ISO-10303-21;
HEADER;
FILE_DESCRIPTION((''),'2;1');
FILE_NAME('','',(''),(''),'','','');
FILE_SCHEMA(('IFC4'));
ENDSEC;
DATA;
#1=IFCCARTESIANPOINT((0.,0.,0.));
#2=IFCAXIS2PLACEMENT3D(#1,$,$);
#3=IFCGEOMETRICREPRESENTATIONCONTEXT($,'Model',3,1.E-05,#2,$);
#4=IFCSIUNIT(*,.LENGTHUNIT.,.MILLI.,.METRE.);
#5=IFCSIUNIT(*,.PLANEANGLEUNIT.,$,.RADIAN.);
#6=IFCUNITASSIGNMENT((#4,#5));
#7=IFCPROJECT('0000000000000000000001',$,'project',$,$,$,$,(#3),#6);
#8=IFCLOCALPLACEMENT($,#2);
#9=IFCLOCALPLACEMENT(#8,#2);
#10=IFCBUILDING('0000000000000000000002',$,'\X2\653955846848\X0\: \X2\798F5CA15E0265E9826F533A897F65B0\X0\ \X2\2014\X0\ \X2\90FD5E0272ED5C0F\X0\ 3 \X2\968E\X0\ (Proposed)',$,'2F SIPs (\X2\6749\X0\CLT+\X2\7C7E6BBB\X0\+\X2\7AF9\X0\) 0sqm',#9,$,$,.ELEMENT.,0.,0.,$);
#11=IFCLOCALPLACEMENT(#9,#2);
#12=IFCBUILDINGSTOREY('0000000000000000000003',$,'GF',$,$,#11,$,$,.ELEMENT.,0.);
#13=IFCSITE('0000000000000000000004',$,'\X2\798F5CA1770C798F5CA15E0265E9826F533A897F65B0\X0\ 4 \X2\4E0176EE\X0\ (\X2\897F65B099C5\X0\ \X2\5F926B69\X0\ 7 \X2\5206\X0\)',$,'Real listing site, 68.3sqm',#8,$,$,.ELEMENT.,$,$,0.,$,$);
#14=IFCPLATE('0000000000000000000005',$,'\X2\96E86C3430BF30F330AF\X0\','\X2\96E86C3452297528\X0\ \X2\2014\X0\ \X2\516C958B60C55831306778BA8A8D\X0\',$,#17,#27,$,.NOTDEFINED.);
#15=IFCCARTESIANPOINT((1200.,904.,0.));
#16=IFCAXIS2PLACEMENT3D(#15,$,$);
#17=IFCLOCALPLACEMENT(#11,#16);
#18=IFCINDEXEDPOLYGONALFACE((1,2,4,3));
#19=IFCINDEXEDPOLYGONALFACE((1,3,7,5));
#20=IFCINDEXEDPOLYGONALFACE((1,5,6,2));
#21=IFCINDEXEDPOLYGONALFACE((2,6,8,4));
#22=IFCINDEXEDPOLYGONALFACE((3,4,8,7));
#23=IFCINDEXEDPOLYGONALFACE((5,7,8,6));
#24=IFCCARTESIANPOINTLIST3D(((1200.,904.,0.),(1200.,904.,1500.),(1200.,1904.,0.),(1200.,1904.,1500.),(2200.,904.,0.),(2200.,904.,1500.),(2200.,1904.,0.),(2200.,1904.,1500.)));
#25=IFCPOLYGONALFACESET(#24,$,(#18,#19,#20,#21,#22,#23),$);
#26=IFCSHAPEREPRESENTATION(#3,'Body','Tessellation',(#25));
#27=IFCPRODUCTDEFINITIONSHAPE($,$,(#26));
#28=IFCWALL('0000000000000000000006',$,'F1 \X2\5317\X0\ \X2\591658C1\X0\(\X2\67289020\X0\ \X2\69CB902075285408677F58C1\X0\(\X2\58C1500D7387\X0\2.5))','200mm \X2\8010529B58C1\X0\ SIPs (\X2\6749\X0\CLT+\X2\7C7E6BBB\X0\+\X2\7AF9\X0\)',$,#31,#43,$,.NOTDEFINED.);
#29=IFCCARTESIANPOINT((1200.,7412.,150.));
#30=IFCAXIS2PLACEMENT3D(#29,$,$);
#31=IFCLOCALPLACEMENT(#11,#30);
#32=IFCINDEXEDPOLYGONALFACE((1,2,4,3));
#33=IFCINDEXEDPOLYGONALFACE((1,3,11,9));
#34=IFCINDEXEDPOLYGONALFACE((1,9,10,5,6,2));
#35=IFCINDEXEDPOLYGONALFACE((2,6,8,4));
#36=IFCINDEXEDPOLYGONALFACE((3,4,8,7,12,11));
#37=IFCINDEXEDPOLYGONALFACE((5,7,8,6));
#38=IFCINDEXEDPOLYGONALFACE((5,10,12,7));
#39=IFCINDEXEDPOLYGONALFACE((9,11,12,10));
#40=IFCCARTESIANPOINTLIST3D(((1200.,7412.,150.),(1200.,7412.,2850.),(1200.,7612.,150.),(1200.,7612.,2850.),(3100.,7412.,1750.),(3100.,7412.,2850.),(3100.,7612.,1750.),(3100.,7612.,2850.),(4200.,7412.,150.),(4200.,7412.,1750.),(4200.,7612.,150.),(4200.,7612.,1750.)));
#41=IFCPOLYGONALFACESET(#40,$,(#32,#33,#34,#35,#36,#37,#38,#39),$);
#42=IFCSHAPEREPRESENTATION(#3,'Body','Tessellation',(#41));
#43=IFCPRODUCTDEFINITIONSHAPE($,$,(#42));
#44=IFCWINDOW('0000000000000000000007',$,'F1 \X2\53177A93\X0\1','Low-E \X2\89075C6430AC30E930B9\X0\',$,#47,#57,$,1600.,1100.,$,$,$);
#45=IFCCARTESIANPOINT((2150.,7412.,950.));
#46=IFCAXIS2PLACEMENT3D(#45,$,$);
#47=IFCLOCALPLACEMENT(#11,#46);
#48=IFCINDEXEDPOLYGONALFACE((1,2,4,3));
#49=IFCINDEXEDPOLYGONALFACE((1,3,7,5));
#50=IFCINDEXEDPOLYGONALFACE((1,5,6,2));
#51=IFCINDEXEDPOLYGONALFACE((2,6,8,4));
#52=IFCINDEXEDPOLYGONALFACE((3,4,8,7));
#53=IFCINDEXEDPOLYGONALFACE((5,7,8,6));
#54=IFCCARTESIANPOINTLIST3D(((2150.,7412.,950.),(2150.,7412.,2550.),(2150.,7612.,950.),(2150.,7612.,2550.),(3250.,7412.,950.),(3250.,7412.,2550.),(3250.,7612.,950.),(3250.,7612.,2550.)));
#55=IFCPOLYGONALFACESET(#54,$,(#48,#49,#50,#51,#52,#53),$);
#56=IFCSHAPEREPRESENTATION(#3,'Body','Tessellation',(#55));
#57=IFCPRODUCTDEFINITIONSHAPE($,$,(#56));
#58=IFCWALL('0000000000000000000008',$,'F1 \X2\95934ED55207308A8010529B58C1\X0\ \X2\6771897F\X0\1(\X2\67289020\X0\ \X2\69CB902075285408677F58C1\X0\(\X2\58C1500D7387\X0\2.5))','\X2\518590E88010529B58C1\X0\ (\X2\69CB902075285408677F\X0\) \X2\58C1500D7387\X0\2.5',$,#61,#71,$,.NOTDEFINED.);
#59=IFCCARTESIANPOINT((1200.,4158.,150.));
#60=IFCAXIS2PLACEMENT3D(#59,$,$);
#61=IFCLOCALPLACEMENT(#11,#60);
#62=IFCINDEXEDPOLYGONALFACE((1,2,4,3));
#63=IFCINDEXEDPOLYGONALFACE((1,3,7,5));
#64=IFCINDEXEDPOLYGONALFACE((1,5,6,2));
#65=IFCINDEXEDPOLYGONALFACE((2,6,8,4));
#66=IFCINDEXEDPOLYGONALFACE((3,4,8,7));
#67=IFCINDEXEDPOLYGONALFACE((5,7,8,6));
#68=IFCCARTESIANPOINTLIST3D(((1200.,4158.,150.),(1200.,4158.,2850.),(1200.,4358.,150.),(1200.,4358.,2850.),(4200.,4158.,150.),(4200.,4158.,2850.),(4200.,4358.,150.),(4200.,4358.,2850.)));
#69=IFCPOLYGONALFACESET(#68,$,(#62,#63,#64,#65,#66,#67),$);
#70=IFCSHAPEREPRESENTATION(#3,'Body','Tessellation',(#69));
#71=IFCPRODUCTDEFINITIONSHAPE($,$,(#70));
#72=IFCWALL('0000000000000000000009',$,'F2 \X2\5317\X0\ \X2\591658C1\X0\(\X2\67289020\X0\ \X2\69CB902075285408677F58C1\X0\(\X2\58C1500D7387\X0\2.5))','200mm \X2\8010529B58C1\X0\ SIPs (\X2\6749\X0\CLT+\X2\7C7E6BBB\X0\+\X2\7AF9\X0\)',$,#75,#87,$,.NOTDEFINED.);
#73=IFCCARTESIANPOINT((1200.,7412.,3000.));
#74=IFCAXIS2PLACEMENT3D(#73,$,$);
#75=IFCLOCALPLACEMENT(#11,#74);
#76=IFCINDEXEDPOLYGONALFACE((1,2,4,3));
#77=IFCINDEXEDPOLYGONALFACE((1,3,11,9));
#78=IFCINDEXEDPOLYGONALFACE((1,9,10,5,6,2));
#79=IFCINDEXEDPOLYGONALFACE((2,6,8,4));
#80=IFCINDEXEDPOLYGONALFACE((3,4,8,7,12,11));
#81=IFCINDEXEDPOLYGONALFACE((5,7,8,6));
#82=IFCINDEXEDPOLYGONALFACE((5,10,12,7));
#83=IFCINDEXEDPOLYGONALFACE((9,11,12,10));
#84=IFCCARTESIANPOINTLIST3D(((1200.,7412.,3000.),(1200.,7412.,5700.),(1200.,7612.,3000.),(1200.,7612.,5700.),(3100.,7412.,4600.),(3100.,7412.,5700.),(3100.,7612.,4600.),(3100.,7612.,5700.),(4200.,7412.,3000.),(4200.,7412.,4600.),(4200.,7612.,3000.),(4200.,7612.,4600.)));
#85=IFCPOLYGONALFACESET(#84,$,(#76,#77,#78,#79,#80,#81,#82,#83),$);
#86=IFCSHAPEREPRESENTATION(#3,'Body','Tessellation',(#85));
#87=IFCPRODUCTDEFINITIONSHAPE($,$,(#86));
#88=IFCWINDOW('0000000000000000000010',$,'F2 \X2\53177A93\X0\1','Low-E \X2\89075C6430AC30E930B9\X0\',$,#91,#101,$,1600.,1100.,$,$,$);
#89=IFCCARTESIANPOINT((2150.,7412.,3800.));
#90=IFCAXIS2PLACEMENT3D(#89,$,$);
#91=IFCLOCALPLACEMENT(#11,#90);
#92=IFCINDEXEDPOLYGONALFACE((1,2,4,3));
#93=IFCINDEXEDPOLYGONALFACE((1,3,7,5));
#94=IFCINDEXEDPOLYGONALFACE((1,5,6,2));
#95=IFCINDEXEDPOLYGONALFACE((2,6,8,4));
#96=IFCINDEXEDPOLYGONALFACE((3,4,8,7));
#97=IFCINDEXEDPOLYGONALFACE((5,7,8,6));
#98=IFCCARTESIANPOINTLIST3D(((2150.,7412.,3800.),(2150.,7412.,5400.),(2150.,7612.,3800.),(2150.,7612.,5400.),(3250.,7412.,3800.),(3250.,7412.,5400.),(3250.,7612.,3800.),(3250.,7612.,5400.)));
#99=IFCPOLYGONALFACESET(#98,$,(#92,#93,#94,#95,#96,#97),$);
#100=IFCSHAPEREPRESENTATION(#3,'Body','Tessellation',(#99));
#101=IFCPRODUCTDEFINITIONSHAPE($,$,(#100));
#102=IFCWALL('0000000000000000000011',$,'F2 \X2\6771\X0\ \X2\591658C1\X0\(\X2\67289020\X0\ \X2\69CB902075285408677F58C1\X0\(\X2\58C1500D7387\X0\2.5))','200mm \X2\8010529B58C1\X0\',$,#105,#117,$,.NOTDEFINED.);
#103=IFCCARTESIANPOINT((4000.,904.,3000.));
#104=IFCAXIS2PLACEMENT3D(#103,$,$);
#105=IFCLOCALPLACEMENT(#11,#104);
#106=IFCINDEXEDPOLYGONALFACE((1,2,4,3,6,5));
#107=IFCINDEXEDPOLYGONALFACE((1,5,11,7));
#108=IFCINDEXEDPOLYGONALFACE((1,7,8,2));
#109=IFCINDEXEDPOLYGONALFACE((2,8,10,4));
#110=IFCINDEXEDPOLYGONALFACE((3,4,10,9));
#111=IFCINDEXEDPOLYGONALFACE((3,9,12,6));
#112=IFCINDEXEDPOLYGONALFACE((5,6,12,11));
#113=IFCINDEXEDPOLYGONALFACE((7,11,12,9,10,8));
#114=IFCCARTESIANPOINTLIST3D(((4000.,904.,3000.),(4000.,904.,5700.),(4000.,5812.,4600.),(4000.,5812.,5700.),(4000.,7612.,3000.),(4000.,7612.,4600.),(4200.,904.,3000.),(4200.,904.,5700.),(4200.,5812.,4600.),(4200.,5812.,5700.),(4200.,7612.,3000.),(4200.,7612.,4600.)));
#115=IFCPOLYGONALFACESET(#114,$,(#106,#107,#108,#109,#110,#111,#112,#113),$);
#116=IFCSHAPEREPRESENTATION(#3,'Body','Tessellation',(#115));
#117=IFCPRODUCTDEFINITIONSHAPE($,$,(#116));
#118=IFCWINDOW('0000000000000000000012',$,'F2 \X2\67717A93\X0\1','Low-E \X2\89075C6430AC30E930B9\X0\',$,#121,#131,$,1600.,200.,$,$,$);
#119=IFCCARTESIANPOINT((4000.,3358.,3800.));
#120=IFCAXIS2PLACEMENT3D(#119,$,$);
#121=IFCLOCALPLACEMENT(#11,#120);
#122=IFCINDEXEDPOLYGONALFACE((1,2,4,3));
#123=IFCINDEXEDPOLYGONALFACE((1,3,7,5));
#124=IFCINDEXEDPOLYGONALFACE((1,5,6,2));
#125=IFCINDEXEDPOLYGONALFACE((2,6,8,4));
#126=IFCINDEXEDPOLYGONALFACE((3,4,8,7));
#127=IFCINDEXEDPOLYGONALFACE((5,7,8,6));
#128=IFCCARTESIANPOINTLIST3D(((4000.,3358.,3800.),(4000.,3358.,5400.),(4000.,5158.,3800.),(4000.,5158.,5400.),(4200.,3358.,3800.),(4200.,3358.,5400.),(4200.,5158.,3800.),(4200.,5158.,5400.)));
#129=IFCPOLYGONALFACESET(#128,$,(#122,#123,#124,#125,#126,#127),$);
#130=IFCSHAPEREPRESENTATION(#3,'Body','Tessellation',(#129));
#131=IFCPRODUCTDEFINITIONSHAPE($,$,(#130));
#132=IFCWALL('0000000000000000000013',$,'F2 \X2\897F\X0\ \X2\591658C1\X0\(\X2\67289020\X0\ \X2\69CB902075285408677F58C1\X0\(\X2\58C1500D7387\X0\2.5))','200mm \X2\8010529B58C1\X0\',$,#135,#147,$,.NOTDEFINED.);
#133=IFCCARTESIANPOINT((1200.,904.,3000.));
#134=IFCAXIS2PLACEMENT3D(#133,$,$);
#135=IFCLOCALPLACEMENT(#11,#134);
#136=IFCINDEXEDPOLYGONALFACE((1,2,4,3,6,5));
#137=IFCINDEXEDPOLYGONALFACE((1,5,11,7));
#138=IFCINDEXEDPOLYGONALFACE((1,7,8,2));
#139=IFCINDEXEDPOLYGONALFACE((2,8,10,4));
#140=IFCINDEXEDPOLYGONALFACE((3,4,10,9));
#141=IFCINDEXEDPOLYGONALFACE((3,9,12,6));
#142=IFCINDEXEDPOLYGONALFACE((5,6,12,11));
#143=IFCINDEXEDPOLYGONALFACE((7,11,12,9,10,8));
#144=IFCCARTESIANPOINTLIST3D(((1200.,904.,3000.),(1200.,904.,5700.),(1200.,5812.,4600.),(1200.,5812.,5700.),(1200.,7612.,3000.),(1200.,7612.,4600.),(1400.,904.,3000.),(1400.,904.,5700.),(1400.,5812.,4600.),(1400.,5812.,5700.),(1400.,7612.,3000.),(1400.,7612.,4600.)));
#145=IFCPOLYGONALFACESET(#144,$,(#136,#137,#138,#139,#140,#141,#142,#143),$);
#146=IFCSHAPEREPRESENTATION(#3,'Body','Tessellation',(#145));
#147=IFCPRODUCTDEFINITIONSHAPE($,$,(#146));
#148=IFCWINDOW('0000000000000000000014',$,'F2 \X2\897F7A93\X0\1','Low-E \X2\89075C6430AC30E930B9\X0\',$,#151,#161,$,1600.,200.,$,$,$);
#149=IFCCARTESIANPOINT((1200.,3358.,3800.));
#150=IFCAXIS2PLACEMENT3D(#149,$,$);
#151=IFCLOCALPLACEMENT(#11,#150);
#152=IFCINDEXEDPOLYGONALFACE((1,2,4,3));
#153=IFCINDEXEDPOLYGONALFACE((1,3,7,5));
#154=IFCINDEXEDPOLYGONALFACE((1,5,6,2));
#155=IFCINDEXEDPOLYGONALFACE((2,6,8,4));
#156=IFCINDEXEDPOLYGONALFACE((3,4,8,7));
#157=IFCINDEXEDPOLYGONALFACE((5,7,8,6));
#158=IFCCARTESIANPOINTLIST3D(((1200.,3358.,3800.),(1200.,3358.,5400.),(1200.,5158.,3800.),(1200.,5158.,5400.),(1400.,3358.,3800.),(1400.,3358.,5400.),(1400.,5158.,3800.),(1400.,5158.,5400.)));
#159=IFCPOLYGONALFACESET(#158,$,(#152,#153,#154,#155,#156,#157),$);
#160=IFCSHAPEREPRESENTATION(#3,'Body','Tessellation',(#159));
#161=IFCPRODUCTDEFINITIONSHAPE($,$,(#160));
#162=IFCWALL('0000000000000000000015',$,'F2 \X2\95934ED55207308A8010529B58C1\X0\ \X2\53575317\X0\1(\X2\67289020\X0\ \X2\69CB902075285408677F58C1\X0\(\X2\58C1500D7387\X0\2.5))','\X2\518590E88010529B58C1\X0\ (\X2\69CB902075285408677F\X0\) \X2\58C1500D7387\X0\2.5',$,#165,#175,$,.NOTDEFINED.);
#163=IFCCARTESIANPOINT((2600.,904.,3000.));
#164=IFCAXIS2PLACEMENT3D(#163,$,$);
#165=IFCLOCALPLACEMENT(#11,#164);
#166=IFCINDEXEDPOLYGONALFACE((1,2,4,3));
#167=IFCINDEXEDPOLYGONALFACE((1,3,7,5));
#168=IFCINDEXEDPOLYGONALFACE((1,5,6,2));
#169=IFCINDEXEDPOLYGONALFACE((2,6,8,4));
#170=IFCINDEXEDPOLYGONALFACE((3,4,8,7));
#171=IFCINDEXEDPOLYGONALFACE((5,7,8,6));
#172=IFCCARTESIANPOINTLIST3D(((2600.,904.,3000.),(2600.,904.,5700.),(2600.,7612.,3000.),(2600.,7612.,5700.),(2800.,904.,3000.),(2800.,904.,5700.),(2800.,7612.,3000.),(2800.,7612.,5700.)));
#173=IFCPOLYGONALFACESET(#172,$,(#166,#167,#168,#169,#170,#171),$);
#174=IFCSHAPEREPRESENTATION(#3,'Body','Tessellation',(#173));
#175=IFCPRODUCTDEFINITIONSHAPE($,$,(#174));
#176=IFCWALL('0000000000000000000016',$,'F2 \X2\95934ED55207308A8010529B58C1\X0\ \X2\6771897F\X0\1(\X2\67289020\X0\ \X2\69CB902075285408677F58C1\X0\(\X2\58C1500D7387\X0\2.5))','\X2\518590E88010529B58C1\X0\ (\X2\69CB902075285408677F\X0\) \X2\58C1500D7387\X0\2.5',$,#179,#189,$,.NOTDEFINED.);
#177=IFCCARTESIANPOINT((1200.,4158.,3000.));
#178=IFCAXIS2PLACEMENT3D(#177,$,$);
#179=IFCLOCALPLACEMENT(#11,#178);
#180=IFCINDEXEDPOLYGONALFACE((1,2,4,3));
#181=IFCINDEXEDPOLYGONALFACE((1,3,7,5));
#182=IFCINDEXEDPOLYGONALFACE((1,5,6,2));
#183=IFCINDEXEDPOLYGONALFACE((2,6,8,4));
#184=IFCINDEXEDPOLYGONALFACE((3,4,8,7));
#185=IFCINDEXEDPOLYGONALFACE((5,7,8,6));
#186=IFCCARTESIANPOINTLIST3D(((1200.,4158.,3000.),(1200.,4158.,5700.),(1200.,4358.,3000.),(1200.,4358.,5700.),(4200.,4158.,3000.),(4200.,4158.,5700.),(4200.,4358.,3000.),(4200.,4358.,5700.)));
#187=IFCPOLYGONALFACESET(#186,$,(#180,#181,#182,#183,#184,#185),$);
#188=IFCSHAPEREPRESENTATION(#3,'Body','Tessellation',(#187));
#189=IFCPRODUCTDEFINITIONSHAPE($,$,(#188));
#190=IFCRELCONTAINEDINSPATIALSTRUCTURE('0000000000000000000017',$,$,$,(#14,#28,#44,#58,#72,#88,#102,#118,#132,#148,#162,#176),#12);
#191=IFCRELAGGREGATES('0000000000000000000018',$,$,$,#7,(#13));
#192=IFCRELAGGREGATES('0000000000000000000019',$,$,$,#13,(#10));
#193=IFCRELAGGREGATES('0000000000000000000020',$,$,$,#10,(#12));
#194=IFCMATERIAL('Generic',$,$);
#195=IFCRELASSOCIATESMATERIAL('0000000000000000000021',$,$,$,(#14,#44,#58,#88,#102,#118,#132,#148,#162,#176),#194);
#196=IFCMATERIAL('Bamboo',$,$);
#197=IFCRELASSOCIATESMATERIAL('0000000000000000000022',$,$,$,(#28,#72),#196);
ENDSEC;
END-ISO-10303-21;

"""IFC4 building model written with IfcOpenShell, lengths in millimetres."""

from ifc_helpers import new_model, si_unit, frame, frame_2d, origin, place, context, project, spatial, rectangle, extrude, material, element, fill, save


model = new_model("IFC4")

# Units and contexts
model_context = context("Model", 3, precision=1e-05, world=origin())
ifc_project = project(units=[si_unit("LENGTHUNIT", "METRE", prefix="MILLI"), si_unit("PLANEANGLEUNIT", "RADIAN")], contexts=[model_context])

# Site, building, storey
site_placement = place(None, origin())
site = spatial("IfcSite", under=ifc_project, at=site_placement, Name="福岡県福岡市早良区西新 4 丁目 (西新駅 徒歩 7 分)", ObjectType="Real listing site, 68.3sqm", CompositionType="ELEMENT", RefElevation=0.0)
building_placement = place(site_placement, origin())
building = spatial("IfcBuilding", under=site, at=building_placement, Name="改善案: 福岡市早良区西新 — 都市狭小 3 階 (Proposed)", ObjectType="2F SIPs (杉CLT+籾殻+竹) 0sqm", CompositionType="ELEMENT", ElevationOfRefHeight=0.0, ElevationOfTerrain=0.0)
storey_placement = place(building_placement, origin())
storey = spatial("IfcBuildingStorey", under=building, at=storey_placement, Name="GF", CompositionType="ELEMENT", Elevation=0.0)

# Plate
ifc_material_1 = material(Name="Generic")
plate_placement = place(storey_placement, frame((1200.0, 904.0, 0.0)))
element("IfcPlate", 1, at=plate_placement, inside=storey, material=ifc_material_1, Name="雨水タンク", Description="雨水利用 — 公開情報で確認", PredefinedType="NOTDEFINED", context=model_context, shape_type="SweptSolid", body=[
    extrude(rectangle(XDim=1000.0, YDim=1000.0, at=frame_2d((500.0, 500.0))), frame((1200.0, 904.0, 0.0)), (0.0, 0.0, 1.0), 1500.0),
])

# Wall, opening, window
ifc_material_2 = material(Name="Bamboo")
wall_1_placement = place(storey_placement, frame((1200.0, 7412.0, 150.0)))
wall_1 = element("IfcWall", 2, at=wall_1_placement, inside=storey, material=ifc_material_2, Name="F1 北 外壁(木造 構造用合板壁(壁倍率2.5))", Description="200mm 耐力壁 SIPs (杉CLT+籾殻+竹)", PredefinedType="NOTDEFINED", context=model_context, shape_type="SweptSolid", body=[
    extrude(rectangle(XDim=3000.0, YDim=200.0, at=frame_2d((1500.0, 100.0))), frame((1200.0, 7412.0, 150.0)), (0.0, 0.0, 1.0), 2700.0),
])
opening_1_placement = place(storey_placement, frame((2150.0, 7412.0, 950.0)))
opening_1 = element("IfcOpeningElement", 3, at=opening_1_placement, cuts=wall_1, PredefinedType="NOTDEFINED", context=model_context, shape_type="SweptSolid", body=[
    extrude(rectangle(XDim=1100.0, YDim=200.0, at=frame_2d((550.0, 100.0))), frame((2150.0, 7412.0, 950.0)), (0.0, 0.0, 1.0), 1600.0),
])
window_1_placement = place(storey_placement, frame((2150.0, 7412.0, 950.0)))
window_1 = element("IfcWindow", 4, at=window_1_placement, inside=storey, material=ifc_material_1, Name="F1 北窓1", Description="Low-E 複層ガラス", OverallHeight=1600.0, OverallWidth=1100.0, context=model_context, shape_type="SweptSolid", body=[
    extrude(rectangle(XDim=1100.0, YDim=200.0, at=frame_2d((550.0, 100.0))), frame((2150.0, 7412.0, 950.0)), (0.0, 0.0, 1.0), 1600.0),
])
fill(opening_1, window_1)

# Wall
wall_2_placement = place(storey_placement, frame((1200.0, 4158.0, 150.0)))
element("IfcWall", 5, at=wall_2_placement, inside=storey, material=ifc_material_1, Name="F1 間仕切り耐力壁 東西1(木造 構造用合板壁(壁倍率2.5))", Description="内部耐力壁 (構造用合板) 壁倍率2.5", PredefinedType="NOTDEFINED", context=model_context, shape_type="SweptSolid", body=[
    extrude(rectangle(XDim=3000.0, YDim=200.0, at=frame_2d((1500.0, 100.0))), frame((1200.0, 4158.0, 150.0)), (0.0, 0.0, 1.0), 2700.0),
])

# Walls, openings, windows
wall_3_placement = place(storey_placement, frame((1200.0, 7412.0, 3000.0)))
wall_3 = element("IfcWall", 6, at=wall_3_placement, inside=storey, material=ifc_material_2, Name="F2 北 外壁(木造 構造用合板壁(壁倍率2.5))", Description="200mm 耐力壁 SIPs (杉CLT+籾殻+竹)", PredefinedType="NOTDEFINED", context=model_context, shape_type="SweptSolid", body=[
    extrude(rectangle(XDim=3000.0, YDim=200.0, at=frame_2d((1500.0, 100.0))), frame((1200.0, 7412.0, 3000.0)), (0.0, 0.0, 1.0), 2700.0),
])
opening_2_placement = place(storey_placement, frame((2150.0, 7412.0, 3800.0)))
opening_2 = element("IfcOpeningElement", 7, at=opening_2_placement, cuts=wall_3, PredefinedType="NOTDEFINED", context=model_context, shape_type="SweptSolid", body=[
    extrude(rectangle(XDim=1100.0, YDim=200.0, at=frame_2d((550.0, 100.0))), frame((2150.0, 7412.0, 3800.0)), (0.0, 0.0, 1.0), 1600.0),
])
window_2_placement = place(storey_placement, frame((2150.0, 7412.0, 3800.0)))
window_2 = element("IfcWindow", 8, at=window_2_placement, inside=storey, material=ifc_material_1, Name="F2 北窓1", Description="Low-E 複層ガラス", OverallHeight=1600.0, OverallWidth=1100.0, context=model_context, shape_type="SweptSolid", body=[
    extrude(rectangle(XDim=1100.0, YDim=200.0, at=frame_2d((550.0, 100.0))), frame((2150.0, 7412.0, 3800.0)), (0.0, 0.0, 1.0), 1600.0),
])
fill(opening_2, window_2)
wall_4_placement = place(storey_placement, frame((4000.0, 904.0, 3000.0)))
wall_4 = element("IfcWall", 9, at=wall_4_placement, inside=storey, material=ifc_material_1, Name="F2 東 外壁(木造 構造用合板壁(壁倍率2.5))", Description="200mm 耐力壁", PredefinedType="NOTDEFINED", context=model_context, shape_type="SweptSolid", body=[
    extrude(rectangle(XDim=200.0, YDim=6708.0, at=frame_2d((100.0, 3354.0))), frame((4000.0, 904.0, 3000.0)), (0.0, 0.0, 1.0), 2700.0),
])
opening_3_placement = place(storey_placement, frame((4000.0, 3358.0, 3800.0)))
opening_3 = element("IfcOpeningElement", 10, at=opening_3_placement, cuts=wall_4, PredefinedType="NOTDEFINED", context=model_context, shape_type="SweptSolid", body=[
    extrude(rectangle(XDim=200.0, YDim=1800.0, at=frame_2d((100.0, 900.0))), frame((4000.0, 3358.0, 3800.0)), (0.0, 0.0, 1.0), 1600.0),
])
window_3_placement = place(storey_placement, frame((4000.0, 3358.0, 3800.0)))
window_3 = element("IfcWindow", 11, at=window_3_placement, inside=storey, material=ifc_material_1, Name="F2 東窓1", Description="Low-E 複層ガラス", OverallHeight=1600.0, OverallWidth=200.0, context=model_context, shape_type="SweptSolid", body=[
    extrude(rectangle(XDim=200.0, YDim=1800.0, at=frame_2d((100.0, 900.0))), frame((4000.0, 3358.0, 3800.0)), (0.0, 0.0, 1.0), 1600.0),
])
fill(opening_3, window_3)
wall_5_placement = place(storey_placement, frame((1200.0, 904.0, 3000.0)))
wall_5 = element("IfcWall", 12, at=wall_5_placement, inside=storey, material=ifc_material_1, Name="F2 西 外壁(木造 構造用合板壁(壁倍率2.5))", Description="200mm 耐力壁", PredefinedType="NOTDEFINED", context=model_context, shape_type="SweptSolid", body=[
    extrude(rectangle(XDim=200.0, YDim=6708.0, at=frame_2d((100.0, 3354.0))), frame((1200.0, 904.0, 3000.0)), (0.0, 0.0, 1.0), 2700.0),
])
opening_4_placement = place(storey_placement, frame((1200.0, 3358.0, 3800.0)))
opening_4 = element("IfcOpeningElement", 13, at=opening_4_placement, cuts=wall_5, PredefinedType="NOTDEFINED", context=model_context, shape_type="SweptSolid", body=[
    extrude(rectangle(XDim=200.0, YDim=1800.0, at=frame_2d((100.0, 900.0))), frame((1200.0, 3358.0, 3800.0)), (0.0, 0.0, 1.0), 1600.0),
])
window_4_placement = place(storey_placement, frame((1200.0, 3358.0, 3800.0)))
window_4 = element("IfcWindow", 14, at=window_4_placement, inside=storey, material=ifc_material_1, Name="F2 西窓1", Description="Low-E 複層ガラス", OverallHeight=1600.0, OverallWidth=200.0, context=model_context, shape_type="SweptSolid", body=[
    extrude(rectangle(XDim=200.0, YDim=1800.0, at=frame_2d((100.0, 900.0))), frame((1200.0, 3358.0, 3800.0)), (0.0, 0.0, 1.0), 1600.0),
])
fill(opening_4, window_4)

# Walls
wall_6_placement = place(storey_placement, frame((2600.0, 904.0, 3000.0)))
element("IfcWall", 15, at=wall_6_placement, inside=storey, material=ifc_material_1, Name="F2 間仕切り耐力壁 南北1(木造 構造用合板壁(壁倍率2.5))", Description="内部耐力壁 (構造用合板) 壁倍率2.5", PredefinedType="NOTDEFINED", context=model_context, shape_type="SweptSolid", body=[
    extrude(rectangle(XDim=200.0, YDim=6708.0, at=frame_2d((100.0, 3354.0))), frame((2600.0, 904.0, 3000.0)), (0.0, 0.0, 1.0), 2700.0),
])
wall_7_placement = place(storey_placement, frame((1200.0, 4158.0, 3000.0)))
element("IfcWall", 16, at=wall_7_placement, inside=storey, material=ifc_material_1, Name="F2 間仕切り耐力壁 東西1(木造 構造用合板壁(壁倍率2.5))", Description="内部耐力壁 (構造用合板) 壁倍率2.5", PredefinedType="NOTDEFINED", context=model_context, shape_type="SweptSolid", body=[
    extrude(rectangle(XDim=3000.0, YDim=200.0, at=frame_2d((1500.0, 100.0))), frame((1200.0, 4158.0, 3000.0)), (0.0, 0.0, 1.0), 2700.0),
])

save(model, "model.ifc")
